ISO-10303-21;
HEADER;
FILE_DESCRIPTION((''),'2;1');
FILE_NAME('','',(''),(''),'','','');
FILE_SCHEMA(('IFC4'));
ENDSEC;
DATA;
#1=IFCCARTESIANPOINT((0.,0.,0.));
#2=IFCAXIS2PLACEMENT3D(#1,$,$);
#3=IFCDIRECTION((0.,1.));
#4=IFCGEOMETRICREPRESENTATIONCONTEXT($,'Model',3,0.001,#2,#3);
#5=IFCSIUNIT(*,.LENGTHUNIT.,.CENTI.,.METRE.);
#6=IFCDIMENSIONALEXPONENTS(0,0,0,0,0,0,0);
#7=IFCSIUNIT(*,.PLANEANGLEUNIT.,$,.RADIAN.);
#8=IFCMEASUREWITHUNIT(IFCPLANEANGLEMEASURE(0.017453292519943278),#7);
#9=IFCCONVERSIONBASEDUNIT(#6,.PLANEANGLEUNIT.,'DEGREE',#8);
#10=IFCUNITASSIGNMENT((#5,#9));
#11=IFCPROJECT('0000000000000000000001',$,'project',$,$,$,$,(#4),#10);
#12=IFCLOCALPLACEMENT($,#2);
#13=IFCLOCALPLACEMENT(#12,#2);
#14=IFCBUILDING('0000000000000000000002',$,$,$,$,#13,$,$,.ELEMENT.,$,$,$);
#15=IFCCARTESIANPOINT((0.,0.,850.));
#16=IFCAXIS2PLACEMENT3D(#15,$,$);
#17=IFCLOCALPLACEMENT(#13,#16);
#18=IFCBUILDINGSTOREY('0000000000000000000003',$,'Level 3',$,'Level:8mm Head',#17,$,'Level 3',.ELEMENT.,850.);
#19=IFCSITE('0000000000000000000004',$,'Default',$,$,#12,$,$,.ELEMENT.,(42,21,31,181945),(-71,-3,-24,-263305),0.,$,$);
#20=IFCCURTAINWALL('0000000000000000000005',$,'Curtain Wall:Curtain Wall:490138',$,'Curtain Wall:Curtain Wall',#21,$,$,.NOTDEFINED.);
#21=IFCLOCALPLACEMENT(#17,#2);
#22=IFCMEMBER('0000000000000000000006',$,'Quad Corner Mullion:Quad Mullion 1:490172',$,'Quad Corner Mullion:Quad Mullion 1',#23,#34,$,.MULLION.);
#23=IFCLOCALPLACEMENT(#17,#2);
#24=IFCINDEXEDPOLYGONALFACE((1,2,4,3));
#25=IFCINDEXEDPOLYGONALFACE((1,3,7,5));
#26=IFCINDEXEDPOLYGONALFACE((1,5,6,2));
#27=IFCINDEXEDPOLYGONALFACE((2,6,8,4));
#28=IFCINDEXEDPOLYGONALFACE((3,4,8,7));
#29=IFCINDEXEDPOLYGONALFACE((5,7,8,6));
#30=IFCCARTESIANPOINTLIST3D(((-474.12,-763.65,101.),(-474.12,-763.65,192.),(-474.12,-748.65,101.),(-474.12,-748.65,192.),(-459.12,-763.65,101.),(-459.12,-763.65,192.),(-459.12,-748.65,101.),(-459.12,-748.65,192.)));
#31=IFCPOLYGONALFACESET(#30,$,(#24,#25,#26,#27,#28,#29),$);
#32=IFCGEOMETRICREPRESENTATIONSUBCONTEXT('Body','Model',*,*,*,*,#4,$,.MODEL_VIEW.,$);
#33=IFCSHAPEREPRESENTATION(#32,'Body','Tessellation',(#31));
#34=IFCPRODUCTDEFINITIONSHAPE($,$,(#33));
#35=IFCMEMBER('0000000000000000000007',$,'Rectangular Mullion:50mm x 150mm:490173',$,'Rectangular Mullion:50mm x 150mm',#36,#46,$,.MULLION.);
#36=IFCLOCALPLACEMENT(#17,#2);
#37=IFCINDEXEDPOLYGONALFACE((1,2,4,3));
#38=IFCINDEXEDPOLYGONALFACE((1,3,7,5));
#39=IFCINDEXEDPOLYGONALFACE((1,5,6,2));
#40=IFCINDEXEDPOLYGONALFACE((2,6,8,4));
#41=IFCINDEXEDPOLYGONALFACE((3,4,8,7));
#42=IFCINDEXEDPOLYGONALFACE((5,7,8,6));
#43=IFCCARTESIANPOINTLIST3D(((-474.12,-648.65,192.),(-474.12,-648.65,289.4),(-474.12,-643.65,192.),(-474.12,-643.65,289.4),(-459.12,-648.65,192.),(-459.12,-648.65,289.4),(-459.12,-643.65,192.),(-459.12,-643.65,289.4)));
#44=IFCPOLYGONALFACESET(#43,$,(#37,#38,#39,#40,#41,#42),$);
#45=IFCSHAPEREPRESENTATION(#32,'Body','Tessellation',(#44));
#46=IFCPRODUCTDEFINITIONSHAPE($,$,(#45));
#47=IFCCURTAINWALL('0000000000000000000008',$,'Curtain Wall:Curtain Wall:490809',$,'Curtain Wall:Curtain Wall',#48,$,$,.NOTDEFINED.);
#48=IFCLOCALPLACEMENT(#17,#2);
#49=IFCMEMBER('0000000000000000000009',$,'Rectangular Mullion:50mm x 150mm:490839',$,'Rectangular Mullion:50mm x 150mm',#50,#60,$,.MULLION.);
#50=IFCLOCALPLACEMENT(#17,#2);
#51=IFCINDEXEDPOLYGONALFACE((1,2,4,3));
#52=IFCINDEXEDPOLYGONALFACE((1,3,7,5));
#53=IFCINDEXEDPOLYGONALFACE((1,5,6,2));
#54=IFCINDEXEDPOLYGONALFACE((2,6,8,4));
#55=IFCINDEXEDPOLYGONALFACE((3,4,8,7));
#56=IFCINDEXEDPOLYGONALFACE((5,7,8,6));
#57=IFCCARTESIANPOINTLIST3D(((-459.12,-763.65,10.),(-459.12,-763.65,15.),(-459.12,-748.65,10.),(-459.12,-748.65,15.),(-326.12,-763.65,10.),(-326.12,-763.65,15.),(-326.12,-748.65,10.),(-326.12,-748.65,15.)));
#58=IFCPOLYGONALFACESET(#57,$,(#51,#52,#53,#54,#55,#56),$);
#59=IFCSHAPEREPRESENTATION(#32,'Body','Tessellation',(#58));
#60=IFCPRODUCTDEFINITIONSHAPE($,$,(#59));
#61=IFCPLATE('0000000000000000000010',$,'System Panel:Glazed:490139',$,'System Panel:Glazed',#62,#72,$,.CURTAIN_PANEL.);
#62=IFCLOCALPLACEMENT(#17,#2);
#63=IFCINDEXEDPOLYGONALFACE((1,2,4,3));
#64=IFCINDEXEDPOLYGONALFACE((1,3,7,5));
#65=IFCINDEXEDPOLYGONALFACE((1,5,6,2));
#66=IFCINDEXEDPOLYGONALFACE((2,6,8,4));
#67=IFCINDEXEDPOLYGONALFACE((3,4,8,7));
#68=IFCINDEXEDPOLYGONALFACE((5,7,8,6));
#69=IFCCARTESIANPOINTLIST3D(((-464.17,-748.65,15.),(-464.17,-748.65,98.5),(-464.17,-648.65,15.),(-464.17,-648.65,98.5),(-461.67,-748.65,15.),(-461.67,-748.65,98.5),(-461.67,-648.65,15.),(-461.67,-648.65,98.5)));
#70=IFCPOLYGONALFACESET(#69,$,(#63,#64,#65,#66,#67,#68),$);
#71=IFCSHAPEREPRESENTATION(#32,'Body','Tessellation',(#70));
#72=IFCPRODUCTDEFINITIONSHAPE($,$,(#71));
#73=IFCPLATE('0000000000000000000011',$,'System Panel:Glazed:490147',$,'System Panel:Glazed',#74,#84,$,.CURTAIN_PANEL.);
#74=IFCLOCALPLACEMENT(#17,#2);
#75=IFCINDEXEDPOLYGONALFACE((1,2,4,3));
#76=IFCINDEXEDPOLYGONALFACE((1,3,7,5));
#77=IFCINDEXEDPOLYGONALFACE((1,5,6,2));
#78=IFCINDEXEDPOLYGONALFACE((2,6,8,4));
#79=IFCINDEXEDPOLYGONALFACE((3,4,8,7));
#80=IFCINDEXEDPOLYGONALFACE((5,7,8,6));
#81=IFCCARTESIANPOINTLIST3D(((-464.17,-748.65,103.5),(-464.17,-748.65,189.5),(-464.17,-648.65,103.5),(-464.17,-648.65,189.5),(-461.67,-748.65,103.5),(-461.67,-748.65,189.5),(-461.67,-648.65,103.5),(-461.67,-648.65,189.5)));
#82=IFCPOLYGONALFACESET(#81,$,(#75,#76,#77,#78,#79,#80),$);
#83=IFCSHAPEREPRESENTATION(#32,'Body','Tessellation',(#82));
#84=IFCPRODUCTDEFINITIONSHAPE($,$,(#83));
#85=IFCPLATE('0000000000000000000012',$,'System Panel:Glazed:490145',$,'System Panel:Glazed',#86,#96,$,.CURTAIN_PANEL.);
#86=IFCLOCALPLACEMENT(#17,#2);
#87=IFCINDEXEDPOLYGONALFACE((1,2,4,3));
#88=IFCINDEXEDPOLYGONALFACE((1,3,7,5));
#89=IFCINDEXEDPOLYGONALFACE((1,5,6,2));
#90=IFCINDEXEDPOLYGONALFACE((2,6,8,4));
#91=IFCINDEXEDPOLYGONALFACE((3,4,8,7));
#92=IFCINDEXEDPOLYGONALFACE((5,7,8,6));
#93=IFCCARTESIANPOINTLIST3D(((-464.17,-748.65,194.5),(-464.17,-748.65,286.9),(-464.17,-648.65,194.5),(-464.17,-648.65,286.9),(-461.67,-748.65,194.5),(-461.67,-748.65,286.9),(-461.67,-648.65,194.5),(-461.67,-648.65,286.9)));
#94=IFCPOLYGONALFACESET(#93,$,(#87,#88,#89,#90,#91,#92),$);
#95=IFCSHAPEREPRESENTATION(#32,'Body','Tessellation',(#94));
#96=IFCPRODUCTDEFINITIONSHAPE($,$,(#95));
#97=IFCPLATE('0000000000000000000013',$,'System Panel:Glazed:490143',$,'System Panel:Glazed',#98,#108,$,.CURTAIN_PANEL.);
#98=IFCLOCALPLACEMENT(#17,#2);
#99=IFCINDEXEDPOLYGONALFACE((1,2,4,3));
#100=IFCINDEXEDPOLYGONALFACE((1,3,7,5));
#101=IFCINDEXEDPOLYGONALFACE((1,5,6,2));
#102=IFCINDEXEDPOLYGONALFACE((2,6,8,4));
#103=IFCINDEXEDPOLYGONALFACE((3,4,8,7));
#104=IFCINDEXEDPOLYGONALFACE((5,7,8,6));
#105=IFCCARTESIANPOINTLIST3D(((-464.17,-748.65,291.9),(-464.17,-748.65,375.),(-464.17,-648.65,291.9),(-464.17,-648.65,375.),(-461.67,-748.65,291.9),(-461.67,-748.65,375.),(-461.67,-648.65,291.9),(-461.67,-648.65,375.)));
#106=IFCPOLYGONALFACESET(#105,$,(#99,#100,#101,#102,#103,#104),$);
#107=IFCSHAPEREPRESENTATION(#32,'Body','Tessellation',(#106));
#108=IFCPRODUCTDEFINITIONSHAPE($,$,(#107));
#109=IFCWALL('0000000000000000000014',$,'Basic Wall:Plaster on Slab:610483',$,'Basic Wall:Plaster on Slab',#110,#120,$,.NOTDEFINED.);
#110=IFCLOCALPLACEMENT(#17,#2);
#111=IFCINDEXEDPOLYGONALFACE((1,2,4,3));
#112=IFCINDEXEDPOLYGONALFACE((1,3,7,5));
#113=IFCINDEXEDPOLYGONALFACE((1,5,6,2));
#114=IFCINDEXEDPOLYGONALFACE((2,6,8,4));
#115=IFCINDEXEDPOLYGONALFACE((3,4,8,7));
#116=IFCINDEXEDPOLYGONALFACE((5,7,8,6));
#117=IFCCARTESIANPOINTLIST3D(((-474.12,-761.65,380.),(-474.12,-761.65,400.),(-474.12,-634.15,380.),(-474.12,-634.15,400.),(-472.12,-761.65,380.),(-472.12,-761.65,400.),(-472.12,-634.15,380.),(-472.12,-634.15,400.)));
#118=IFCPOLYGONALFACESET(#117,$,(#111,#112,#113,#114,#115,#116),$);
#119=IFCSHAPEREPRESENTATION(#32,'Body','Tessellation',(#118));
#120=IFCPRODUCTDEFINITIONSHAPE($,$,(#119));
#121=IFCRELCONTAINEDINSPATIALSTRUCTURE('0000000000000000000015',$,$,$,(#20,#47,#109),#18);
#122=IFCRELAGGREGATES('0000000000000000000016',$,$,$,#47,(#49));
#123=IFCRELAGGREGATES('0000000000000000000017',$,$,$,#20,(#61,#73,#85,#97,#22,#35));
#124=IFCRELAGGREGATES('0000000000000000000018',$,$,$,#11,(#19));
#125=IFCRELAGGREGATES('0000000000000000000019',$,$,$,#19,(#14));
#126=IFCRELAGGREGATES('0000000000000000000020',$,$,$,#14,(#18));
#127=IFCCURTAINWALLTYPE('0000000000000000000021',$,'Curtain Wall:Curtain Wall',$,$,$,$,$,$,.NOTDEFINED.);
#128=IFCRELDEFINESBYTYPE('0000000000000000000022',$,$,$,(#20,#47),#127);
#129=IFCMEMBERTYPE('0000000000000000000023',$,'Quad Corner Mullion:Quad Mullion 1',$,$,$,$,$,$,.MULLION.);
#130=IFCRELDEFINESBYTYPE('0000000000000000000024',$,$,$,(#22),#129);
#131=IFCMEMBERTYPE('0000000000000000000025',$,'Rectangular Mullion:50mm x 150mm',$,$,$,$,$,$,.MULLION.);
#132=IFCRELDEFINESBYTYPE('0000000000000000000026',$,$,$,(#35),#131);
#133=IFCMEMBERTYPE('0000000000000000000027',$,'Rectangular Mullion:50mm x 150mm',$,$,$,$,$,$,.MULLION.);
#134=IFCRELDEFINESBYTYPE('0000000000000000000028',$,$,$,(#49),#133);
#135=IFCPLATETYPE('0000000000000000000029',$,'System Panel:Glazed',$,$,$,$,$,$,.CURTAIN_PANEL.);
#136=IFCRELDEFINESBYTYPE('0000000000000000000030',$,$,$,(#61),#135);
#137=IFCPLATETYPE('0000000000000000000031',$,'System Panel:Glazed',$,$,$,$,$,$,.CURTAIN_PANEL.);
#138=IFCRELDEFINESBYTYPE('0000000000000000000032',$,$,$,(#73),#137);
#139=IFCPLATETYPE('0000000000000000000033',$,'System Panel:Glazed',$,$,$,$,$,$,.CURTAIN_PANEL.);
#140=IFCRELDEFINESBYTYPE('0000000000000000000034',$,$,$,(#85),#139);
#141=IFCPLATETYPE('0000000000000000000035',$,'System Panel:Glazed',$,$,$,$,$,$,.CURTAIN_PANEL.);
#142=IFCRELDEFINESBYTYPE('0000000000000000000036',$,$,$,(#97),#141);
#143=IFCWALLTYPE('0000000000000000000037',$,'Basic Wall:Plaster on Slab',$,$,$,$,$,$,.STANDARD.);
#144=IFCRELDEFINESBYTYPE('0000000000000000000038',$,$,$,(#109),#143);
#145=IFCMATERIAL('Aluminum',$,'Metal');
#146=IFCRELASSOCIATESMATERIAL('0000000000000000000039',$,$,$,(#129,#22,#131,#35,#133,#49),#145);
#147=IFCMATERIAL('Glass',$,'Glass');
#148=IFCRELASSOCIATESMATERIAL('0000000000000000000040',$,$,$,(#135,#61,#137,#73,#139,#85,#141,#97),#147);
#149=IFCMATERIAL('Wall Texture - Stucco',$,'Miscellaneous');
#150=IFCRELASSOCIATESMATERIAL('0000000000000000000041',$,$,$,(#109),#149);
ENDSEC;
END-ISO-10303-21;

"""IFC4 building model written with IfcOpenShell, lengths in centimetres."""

from ifc_helpers import new_model, entity, si_unit, converted_unit, direction, frame, origin, place, context, subcontext, project, spatial, indexed_curve, outline, extrude, source, transform, mapped, material, type_object, type_shapes, element, aggregate, save


model = new_model("IFC4")

# Units and contexts
model_context = context("Model", 3, precision=0.001, world=origin(), true_north=direction((0.0, 1.0)))
body_context = subcontext(model_context, "Body", "Model", "MODEL_VIEW")
ifc_project = project(units=[si_unit("LENGTHUNIT", "METRE", prefix="CENTI"), converted_unit("PLANEANGLEUNIT", "DEGREE", entity("IfcPlaneAngleMeasure", 0.017453292519943278), si_unit("PLANEANGLEUNIT", "RADIAN"), dimensions=[0, 0, 0, 0, 0, 0, 0])], contexts=[model_context])

# Site, building, storey
site_placement = place(None, origin())
site = spatial("IfcSite", under=ifc_project, at=site_placement, Name="Default", CompositionType="ELEMENT", RefLatitude=(42, 21, 31, 181945), RefLongitude=(-71, -3, -24, -263305), RefElevation=0.0)
building_placement = place(site_placement, origin())
building = spatial("IfcBuilding", under=site, at=building_placement, CompositionType="ELEMENT")
storey_placement = place(building_placement, frame((0.0, 0.0, 850.0)))
storey = spatial("IfcBuildingStorey", under=building, at=storey_placement, Name="Level 3", ObjectType="Level:8mm Head", LongName="Level 3", CompositionType="ELEMENT", Elevation=850.0)

# Curtain wall, members
curtain_wall_type = type_object("IfcCurtainWallType", Name="Curtain Wall:Curtain Wall", PredefinedType="NOTDEFINED")
curtain_wall_1_placement = place(storey_placement, frame((0.0, 0.0, -850.0)))
curtain_wall_1 = element("IfcCurtainWall", 1, at=curtain_wall_1_placement, inside=storey, type_object=curtain_wall_type, Name="Curtain Wall:Curtain Wall:490138", ObjectType="Curtain Wall:Curtain Wall", PredefinedType="NOTDEFINED")
ifc_material_1 = material(Name="Aluminum", Category="Metal")
member_type_1 = type_object("IfcMemberType", Name="Quad Corner Mullion:Quad Mullion 1", PredefinedType="MULLION", material=ifc_material_1)
shared_shape_1 = source(origin(), body_context, "Body", "SweptSolid", [
    extrude(outline(indexed_curve([(-7.5, -7.5), (7.5, -7.5), (7.5, 7.5), (-7.5, 7.5), (-7.5, -7.5)], self_intersect=False)), frame((0.0, 0.0, -91.0), z_axis=(0.0, 0.0, 1.0), x_axis=(0.0, 1.0, 0.0)), (0.0, 0.0, 1.0), 91.0),
])
type_shapes(member_type_1, [shared_shape_1])
member_1_placement = place(curtain_wall_1_placement, frame((-466.62, -756.15, 951.0), z_axis=(0.0, 0.0, -1.0), x_axis=(0.0, -1.0, 0.0)))
member_1 = element("IfcMember", 2, at=member_1_placement, type_object=member_type_1, material=ifc_material_1, Name="Quad Corner Mullion:Quad Mullion 1:490172", ObjectType="Quad Corner Mullion:Quad Mullion 1", PredefinedType="MULLION", context=body_context, shape_type="MappedRepresentation", body=[
    mapped(shared_shape_1, transform((0.0, 0.0, 0.0), scale=1.0)),
])
member_type_2 = type_object("IfcMemberType", Name="Rectangular Mullion:50mm x 150mm", PredefinedType="MULLION", material=ifc_material_1)
shared_shape_2 = source(origin(), body_context, "Body", "SweptSolid", [
    extrude(outline(indexed_curve([(-2.5, -7.5), (2.5, -7.5), (2.5, 7.5), (-2.5, 7.5), (-2.5, -7.5)], self_intersect=False)), frame((-2.5, 0.0, -97.4), z_axis=(0.0, 0.0, 1.0), x_axis=(-1.0, 0.0, 0.0)), (0.0, 0.0, 1.0), 97.4),
])
type_shapes(member_type_2, [shared_shape_2])
member_2_placement = place(curtain_wall_1_placement, frame((-466.62, -643.65, 1139.4), z_axis=(0.0, 0.0, 1.0), x_axis=(0.0, 1.0, 0.0)))
member_2 = element("IfcMember", 3, at=member_2_placement, type_object=member_type_2, material=ifc_material_1, Name="Rectangular Mullion:50mm x 150mm:490173", ObjectType="Rectangular Mullion:50mm x 150mm", PredefinedType="MULLION", context=body_context, shape_type="MappedRepresentation", body=[
    mapped(shared_shape_2, transform((0.0, 0.0, 0.0), scale=1.0)),
])

# Curtain wall, member
curtain_wall_2_placement = place(storey_placement, frame((0.0, 0.0, -850.0)))
curtain_wall_2 = element("IfcCurtainWall", 4, at=curtain_wall_2_placement, inside=storey, type_object=curtain_wall_type, Name="Curtain Wall:Curtain Wall:490809", ObjectType="Curtain Wall:Curtain Wall", PredefinedType="NOTDEFINED")
member_type_3 = type_object("IfcMemberType", Name="Rectangular Mullion:50mm x 150mm", PredefinedType="MULLION", material=ifc_material_1)
shared_shape_3 = source(origin(), body_context, "Body", "SweptSolid", [
    extrude(outline(indexed_curve([(-2.5, -7.5), (2.5, -7.5), (2.5, 7.5), (-2.5, 7.5), (-2.5, -7.5)], self_intersect=False)), frame((-2.5, 0.0, -133.0), z_axis=(0.0, 0.0, 1.0), x_axis=(-1.0, 0.0, 0.0)), (0.0, 0.0, 1.0), 133.0),
])
type_shapes(member_type_3, [shared_shape_3])
member_3_placement = place(curtain_wall_2_placement, frame((-459.12, -756.15, 860.0), z_axis=(-1.0, 0.0, 0.0), x_axis=(0.0, 0.0, -1.0)))
member_3 = element("IfcMember", 5, at=member_3_placement, type_object=member_type_3, material=ifc_material_1, Name="Rectangular Mullion:50mm x 150mm:490839", ObjectType="Rectangular Mullion:50mm x 150mm", PredefinedType="MULLION", context=body_context, shape_type="MappedRepresentation", body=[
    mapped(shared_shape_3, transform((0.0, 0.0, 0.0), scale=1.0)),
])
aggregate(curtain_wall_2, [member_3])

# Plates
ifc_material_2 = material(Name="Glass", Category="Glass")
plate_type_1 = type_object("IfcPlateType", Name="System Panel:Glazed", PredefinedType="CURTAIN_PANEL", material=ifc_material_2)
shared_shape_4 = source(origin(), body_context, "Body", "SweptSolid", [
    extrude(outline(indexed_curve([(-1.25, -50.0), (1.25, -50.0), (1.25, 50.0), (-1.25, 50.0), (-1.25, -50.0)], self_intersect=False)), frame((0.0, 3.7, 0.0), z_axis=(0.0, 0.0, 1.0), x_axis=(0.0, 1.0, 0.0)), (0.0, 0.0, 1.0), 83.5),
])
type_shapes(plate_type_1, [shared_shape_4])
plate_1_placement = place(curtain_wall_1_placement, frame((-466.62, -698.65, 865.0), z_axis=(0.0, 0.0, 1.0), x_axis=(0.0, -1.0, 0.0)))
plate_1 = element("IfcPlate", 6, at=plate_1_placement, type_object=plate_type_1, material=ifc_material_2, Name="System Panel:Glazed:490139", ObjectType="System Panel:Glazed", PredefinedType="CURTAIN_PANEL", context=body_context, shape_type="MappedRepresentation", body=[
    mapped(shared_shape_4, transform((0.0, 0.0, 0.0), scale=1.0)),
])
plate_type_2 = type_object("IfcPlateType", Name="System Panel:Glazed", PredefinedType="CURTAIN_PANEL", material=ifc_material_2)
shared_shape_5 = source(origin(), body_context, "Body", "SweptSolid", [
    extrude(outline(indexed_curve([(-1.25, -50.0), (1.25, -50.0), (1.25, 50.0), (-1.25, 50.0), (-1.25, -50.0)], self_intersect=False)), frame((0.0, 3.7, 0.0), z_axis=(0.0, 0.0, 1.0), x_axis=(0.0, 1.0, 0.0)), (0.0, 0.0, 1.0), 86.0),
])
type_shapes(plate_type_2, [shared_shape_5])
plate_2_placement = place(curtain_wall_1_placement, frame((-466.62, -698.65, 953.5), z_axis=(0.0, 0.0, 1.0), x_axis=(0.0, -1.0, 0.0)))
plate_2 = element("IfcPlate", 7, at=plate_2_placement, type_object=plate_type_2, material=ifc_material_2, Name="System Panel:Glazed:490147", ObjectType="System Panel:Glazed", PredefinedType="CURTAIN_PANEL", context=body_context, shape_type="MappedRepresentation", body=[
    mapped(shared_shape_5, transform((0.0, 0.0, 0.0), scale=1.0)),
])
plate_type_3 = type_object("IfcPlateType", Name="System Panel:Glazed", PredefinedType="CURTAIN_PANEL", material=ifc_material_2)
shared_shape_6 = source(origin(), body_context, "Body", "SweptSolid", [
    extrude(outline(indexed_curve([(-1.25, -50.0), (1.25, -50.0), (1.25, 50.0), (-1.25, 50.0), (-1.25, -50.0)], self_intersect=False)), frame((0.0, 3.7, 0.0), z_axis=(0.0, 0.0, 1.0), x_axis=(0.0, 1.0, 0.0)), (0.0, 0.0, 1.0), 92.4),
])
type_shapes(plate_type_3, [shared_shape_6])
plate_3_placement = place(curtain_wall_1_placement, frame((-466.62, -698.65, 1044.5), z_axis=(0.0, 0.0, 1.0), x_axis=(0.0, -1.0, 0.0)))
plate_3 = element("IfcPlate", 8, at=plate_3_placement, type_object=plate_type_3, material=ifc_material_2, Name="System Panel:Glazed:490145", ObjectType="System Panel:Glazed", PredefinedType="CURTAIN_PANEL", context=body_context, shape_type="MappedRepresentation", body=[
    mapped(shared_shape_6, transform((0.0, 0.0, 0.0), scale=1.0)),
])
plate_type_4 = type_object("IfcPlateType", Name="System Panel:Glazed", PredefinedType="CURTAIN_PANEL", material=ifc_material_2)
shared_shape_7 = source(origin(), body_context, "Body", "SweptSolid", [
    extrude(outline(indexed_curve([(-1.25, -50.0), (1.25, -50.0), (1.25, 50.0), (-1.25, 50.0), (-1.25, -50.0)], self_intersect=False)), frame((0.0, 3.7, 0.0), z_axis=(0.0, 0.0, 1.0), x_axis=(0.0, 1.0, 0.0)), (0.0, 0.0, 1.0), 83.1),
])
type_shapes(plate_type_4, [shared_shape_7])
plate_4_placement = place(curtain_wall_1_placement, frame((-466.62, -698.65, 1141.9), z_axis=(0.0, 0.0, 1.0), x_axis=(0.0, -1.0, 0.0)))
plate_4 = element("IfcPlate", 9, at=plate_4_placement, type_object=plate_type_4, material=ifc_material_2, Name="System Panel:Glazed:490143", ObjectType="System Panel:Glazed", PredefinedType="CURTAIN_PANEL", context=body_context, shape_type="MappedRepresentation", body=[
    mapped(shared_shape_7, transform((0.0, 0.0, 0.0), scale=1.0)),
])
aggregate(curtain_wall_1, [plate_1, plate_2, plate_3, plate_4, member_1, member_2])

# Shared definitions
ifc_material_3 = material(Name="Wall Texture - Stucco", Category="Miscellaneous")

# Wall
wall_type_1 = type_object("IfcWallType", Name="Basic Wall:Plaster on Slab", PredefinedType="STANDARD")
wall_1_placement = place(storey_placement, frame((-473.12, -761.65, 380.0), z_axis=(0.0, 0.0, 1.0), x_axis=(0.0, 1.0, 0.0)))
element("IfcWall", 10, at=wall_1_placement, inside=storey, type_object=wall_type_1, material=ifc_material_3, Name="Basic Wall:Plaster on Slab:610483", ObjectType="Basic Wall:Plaster on Slab", PredefinedType="NOTDEFINED", context=body_context, shape_type="SweptSolid", body=[
    extrude(outline(indexed_curve([(127.5, 1.0), (0.0, 1.0), (0.0, -1.0), (127.5, -1.0), (127.5, 1.0)], self_intersect=False)), origin(), (0.0, 0.0, 1.0), 20.0),
])

save(model, "model.ifc")
